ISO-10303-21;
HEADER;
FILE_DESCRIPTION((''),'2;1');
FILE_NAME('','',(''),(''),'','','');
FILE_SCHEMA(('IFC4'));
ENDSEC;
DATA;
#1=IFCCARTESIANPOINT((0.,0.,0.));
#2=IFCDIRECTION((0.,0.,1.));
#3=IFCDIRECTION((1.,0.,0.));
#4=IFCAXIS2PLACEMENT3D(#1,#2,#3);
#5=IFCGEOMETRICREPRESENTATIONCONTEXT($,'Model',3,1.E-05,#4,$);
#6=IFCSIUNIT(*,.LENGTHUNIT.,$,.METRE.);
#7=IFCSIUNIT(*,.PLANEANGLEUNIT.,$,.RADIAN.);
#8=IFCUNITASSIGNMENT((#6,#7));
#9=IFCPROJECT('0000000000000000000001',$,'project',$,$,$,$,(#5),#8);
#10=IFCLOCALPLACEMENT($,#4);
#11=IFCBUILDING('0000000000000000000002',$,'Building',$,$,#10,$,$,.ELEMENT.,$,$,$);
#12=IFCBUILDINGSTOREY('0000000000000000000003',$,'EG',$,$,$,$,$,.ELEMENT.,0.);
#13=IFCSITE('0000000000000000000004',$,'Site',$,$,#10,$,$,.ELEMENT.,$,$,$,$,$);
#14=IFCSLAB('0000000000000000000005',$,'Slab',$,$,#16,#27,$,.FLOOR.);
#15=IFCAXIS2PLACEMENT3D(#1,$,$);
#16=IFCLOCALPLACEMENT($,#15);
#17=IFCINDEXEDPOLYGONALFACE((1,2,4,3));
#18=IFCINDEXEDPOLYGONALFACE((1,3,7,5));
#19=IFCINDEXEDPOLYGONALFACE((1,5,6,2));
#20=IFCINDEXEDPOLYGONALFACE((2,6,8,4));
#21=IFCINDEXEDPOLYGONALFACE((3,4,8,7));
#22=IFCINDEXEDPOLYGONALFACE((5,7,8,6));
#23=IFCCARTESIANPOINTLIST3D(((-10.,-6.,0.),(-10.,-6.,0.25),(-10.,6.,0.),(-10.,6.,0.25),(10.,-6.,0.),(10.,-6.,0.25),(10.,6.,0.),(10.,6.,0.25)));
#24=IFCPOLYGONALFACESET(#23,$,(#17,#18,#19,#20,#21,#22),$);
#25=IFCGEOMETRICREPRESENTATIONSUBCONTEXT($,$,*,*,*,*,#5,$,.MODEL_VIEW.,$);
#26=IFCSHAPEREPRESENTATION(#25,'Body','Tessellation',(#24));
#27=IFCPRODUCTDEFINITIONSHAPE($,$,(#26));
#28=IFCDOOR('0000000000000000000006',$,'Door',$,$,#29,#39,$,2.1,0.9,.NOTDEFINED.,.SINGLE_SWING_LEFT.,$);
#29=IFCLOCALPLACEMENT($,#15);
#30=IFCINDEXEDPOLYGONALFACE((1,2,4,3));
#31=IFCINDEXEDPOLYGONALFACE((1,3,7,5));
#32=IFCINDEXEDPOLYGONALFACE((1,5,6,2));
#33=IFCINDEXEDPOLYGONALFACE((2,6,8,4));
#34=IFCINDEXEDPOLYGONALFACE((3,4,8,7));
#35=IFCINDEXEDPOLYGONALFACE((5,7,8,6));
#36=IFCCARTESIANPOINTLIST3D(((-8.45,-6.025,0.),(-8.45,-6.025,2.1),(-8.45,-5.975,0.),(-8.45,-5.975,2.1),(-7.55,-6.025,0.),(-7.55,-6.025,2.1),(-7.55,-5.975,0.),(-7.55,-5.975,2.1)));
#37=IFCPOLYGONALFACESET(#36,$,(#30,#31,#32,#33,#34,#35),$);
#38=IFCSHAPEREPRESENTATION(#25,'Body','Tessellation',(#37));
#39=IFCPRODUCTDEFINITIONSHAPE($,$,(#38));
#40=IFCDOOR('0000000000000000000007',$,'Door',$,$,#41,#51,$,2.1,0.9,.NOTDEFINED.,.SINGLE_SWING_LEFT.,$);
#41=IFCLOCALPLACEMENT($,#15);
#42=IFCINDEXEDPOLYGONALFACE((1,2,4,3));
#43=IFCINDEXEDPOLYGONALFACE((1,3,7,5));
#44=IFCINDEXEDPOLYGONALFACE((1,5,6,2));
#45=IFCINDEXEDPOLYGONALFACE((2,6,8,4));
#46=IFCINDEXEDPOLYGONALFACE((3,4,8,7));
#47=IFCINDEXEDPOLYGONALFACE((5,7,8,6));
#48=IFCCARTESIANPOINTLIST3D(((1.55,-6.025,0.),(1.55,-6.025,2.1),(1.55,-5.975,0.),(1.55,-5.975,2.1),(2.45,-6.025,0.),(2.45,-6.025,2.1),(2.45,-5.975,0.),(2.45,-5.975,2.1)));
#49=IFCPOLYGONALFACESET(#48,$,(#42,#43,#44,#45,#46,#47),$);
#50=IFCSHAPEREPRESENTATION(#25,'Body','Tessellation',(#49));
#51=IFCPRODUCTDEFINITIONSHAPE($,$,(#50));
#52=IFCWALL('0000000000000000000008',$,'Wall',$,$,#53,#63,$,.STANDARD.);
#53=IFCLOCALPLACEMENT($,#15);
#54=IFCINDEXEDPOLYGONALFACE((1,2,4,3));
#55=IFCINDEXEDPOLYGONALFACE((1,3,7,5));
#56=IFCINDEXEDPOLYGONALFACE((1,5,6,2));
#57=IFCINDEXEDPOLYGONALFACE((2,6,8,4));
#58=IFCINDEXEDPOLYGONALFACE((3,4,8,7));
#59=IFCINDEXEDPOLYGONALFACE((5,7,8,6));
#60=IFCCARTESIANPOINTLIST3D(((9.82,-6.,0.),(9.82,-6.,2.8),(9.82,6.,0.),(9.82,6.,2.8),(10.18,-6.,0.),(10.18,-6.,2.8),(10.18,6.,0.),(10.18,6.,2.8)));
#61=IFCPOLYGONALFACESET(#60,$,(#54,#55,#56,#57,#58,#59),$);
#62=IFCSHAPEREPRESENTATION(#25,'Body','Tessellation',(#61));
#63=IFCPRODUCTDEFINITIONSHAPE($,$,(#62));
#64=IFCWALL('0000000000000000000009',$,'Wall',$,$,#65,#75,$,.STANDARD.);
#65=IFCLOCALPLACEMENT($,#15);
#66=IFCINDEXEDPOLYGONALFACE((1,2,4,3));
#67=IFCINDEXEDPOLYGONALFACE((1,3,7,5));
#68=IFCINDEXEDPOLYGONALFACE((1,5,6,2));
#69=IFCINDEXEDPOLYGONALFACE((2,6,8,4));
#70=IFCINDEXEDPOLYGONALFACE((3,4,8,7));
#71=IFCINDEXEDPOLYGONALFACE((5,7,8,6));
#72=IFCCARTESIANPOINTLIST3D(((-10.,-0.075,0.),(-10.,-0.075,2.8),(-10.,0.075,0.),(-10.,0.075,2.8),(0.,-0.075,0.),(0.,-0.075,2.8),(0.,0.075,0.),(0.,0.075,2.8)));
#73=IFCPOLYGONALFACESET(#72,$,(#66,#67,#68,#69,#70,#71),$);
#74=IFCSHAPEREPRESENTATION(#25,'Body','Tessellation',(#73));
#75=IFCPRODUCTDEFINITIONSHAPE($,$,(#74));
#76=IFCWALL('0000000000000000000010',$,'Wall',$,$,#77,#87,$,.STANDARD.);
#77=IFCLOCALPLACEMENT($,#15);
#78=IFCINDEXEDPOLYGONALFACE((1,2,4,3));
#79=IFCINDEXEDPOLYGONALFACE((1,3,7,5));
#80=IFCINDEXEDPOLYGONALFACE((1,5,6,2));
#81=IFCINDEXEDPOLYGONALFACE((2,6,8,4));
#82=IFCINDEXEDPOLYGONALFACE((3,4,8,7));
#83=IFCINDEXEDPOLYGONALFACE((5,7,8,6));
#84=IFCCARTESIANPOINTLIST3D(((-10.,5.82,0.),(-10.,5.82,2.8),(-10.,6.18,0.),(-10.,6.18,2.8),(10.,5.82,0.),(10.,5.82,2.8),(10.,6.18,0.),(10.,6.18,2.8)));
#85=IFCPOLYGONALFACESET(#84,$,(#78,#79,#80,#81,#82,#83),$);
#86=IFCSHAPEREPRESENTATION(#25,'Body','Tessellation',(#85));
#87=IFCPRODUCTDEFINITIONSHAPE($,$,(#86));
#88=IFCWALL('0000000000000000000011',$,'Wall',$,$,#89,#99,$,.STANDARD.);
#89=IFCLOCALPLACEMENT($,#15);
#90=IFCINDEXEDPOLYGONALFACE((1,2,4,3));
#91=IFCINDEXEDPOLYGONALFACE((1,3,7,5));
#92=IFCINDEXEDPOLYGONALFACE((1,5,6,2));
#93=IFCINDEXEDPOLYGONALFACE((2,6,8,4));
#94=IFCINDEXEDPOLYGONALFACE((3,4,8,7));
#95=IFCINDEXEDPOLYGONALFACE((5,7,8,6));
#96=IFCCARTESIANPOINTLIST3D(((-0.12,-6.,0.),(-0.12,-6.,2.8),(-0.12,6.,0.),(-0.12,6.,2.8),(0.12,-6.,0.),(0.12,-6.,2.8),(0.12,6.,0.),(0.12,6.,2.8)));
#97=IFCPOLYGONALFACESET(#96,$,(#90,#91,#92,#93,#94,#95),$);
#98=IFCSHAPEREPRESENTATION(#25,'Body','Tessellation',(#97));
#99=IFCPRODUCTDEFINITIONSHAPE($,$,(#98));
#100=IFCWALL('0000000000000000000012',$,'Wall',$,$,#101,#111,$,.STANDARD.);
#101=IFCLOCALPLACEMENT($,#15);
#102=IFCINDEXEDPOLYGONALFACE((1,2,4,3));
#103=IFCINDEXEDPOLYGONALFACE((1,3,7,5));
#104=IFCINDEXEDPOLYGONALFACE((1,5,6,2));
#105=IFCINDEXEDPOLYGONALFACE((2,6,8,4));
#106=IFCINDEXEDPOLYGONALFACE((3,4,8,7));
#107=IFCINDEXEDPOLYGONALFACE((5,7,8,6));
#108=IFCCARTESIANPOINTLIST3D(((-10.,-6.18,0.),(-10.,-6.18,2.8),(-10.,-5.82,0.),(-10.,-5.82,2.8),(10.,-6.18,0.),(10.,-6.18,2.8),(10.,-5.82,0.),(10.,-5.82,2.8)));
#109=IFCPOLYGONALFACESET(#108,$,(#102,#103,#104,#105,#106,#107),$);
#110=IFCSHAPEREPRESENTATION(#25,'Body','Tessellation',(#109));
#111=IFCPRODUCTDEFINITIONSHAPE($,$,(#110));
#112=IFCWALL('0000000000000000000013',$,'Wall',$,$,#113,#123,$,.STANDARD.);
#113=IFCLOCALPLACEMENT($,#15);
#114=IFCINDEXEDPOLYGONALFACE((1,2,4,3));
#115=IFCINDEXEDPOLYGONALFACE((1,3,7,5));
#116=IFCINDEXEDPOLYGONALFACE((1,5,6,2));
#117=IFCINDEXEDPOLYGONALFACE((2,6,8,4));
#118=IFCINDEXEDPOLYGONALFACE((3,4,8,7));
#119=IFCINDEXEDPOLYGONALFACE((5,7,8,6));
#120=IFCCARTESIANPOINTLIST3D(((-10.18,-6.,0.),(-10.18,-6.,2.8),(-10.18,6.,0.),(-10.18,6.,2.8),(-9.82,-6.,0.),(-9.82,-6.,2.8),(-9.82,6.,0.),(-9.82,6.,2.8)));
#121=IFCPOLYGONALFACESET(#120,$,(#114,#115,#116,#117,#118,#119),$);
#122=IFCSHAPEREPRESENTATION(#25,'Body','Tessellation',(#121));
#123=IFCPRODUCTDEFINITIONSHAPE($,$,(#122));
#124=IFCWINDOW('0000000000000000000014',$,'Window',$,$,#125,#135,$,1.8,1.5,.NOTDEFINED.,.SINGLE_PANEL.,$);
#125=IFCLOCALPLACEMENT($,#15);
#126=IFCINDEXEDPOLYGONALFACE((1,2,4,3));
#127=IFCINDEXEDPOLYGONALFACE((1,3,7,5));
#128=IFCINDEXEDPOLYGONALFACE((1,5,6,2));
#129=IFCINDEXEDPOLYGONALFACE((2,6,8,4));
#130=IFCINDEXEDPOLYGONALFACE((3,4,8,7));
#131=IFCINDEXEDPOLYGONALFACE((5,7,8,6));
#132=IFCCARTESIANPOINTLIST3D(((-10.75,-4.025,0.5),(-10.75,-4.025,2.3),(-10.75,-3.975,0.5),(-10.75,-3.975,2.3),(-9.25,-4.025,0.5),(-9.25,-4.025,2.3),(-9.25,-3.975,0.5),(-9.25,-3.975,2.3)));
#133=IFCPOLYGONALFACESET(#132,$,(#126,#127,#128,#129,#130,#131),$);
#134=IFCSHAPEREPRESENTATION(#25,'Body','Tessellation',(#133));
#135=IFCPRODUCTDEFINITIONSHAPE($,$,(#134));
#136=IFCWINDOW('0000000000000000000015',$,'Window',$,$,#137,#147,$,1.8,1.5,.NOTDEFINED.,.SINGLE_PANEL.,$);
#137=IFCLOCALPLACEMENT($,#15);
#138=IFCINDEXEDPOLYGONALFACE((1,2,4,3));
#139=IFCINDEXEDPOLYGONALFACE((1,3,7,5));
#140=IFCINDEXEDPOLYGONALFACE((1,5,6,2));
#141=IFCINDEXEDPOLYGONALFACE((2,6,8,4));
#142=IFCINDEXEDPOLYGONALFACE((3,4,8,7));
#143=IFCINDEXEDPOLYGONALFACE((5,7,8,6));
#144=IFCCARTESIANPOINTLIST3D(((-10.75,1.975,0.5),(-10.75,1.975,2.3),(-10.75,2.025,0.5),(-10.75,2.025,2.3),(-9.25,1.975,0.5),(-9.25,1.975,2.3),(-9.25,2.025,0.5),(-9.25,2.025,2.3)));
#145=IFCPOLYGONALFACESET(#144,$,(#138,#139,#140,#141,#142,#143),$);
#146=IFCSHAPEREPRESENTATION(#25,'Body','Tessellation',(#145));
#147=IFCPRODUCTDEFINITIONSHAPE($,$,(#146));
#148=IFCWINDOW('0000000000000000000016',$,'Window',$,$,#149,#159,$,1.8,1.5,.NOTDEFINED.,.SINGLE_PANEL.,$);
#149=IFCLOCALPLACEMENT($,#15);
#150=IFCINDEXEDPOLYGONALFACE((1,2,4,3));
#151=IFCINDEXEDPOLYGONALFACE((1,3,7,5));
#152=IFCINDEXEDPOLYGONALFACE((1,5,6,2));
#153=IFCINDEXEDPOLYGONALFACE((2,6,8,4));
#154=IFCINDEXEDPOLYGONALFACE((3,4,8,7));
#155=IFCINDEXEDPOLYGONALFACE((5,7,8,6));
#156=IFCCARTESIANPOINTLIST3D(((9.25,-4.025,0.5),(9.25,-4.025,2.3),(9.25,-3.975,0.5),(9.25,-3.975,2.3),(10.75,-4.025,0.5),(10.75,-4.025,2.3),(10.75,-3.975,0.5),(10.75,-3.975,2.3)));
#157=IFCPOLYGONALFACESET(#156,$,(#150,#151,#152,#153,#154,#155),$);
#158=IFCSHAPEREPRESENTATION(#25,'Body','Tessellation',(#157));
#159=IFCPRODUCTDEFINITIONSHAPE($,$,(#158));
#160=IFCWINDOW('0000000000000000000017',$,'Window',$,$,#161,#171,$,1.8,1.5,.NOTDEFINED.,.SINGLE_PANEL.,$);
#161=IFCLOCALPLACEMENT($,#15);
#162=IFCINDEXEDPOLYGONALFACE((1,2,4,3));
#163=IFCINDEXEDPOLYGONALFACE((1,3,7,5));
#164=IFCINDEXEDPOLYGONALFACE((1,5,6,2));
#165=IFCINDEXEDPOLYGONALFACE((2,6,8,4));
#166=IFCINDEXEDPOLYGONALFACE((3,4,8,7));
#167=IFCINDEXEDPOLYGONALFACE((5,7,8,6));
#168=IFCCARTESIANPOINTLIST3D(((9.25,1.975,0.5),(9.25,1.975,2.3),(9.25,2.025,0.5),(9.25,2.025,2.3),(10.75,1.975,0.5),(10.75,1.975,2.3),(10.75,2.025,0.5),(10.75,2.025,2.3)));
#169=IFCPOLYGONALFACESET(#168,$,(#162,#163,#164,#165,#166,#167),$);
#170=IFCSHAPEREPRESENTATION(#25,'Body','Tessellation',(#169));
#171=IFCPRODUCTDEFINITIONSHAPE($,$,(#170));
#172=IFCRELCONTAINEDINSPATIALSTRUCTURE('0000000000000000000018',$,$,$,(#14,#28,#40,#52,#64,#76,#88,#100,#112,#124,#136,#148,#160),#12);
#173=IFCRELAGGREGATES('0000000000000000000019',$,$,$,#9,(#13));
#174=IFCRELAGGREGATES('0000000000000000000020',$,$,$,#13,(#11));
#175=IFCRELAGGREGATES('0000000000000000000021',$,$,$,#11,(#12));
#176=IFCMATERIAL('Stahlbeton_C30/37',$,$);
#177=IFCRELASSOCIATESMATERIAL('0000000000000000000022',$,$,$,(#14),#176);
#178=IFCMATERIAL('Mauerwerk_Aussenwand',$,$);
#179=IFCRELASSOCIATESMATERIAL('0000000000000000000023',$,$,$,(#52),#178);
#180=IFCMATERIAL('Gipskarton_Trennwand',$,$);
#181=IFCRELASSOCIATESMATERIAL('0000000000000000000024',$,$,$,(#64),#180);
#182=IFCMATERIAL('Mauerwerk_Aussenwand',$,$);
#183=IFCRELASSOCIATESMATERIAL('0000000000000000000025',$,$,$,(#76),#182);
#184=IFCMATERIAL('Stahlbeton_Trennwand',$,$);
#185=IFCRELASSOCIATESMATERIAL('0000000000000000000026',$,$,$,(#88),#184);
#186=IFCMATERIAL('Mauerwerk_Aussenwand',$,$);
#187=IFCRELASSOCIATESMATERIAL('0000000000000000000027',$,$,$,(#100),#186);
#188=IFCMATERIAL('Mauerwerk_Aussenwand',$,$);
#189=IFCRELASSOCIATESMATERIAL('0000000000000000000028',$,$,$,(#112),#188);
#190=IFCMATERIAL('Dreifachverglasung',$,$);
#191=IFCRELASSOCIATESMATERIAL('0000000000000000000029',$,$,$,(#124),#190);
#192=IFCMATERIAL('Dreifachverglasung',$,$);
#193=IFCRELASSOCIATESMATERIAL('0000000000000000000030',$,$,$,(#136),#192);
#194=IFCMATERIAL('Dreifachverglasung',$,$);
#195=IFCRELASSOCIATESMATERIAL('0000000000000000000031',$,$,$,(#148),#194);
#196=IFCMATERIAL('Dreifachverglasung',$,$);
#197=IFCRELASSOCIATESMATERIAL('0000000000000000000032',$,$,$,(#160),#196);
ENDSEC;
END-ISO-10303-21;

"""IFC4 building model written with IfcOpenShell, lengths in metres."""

from ifc_helpers import new_model, si_unit, frame, frame_2d, origin, origin_with_axes, origin_2d, place, context, subcontext, project, spatial, rectangle, extrude, material, element, save


model = new_model("IFC4")

# Units and contexts
model_context = context("Model", 3, precision=1e-05, world=origin_with_axes())
sub_context = subcontext(model_context, None, None, "MODEL_VIEW")
ifc_project = project(units=[si_unit("LENGTHUNIT", "METRE"), si_unit("PLANEANGLEUNIT", "RADIAN")], contexts=[model_context])

# Site, building, storey
placement_1 = place(None, origin_with_axes())
site = spatial("IfcSite", under=ifc_project, at=placement_1, Name="Site", CompositionType="ELEMENT")
building = spatial("IfcBuilding", under=site, at=placement_1, Name="Building", CompositionType="ELEMENT")
storey = spatial("IfcBuildingStorey", under=building, Name="EG", CompositionType="ELEMENT", Elevation=0.0)

# Slab
ifc_material_1 = material(Name="Stahlbeton_C30/37")
placement_2 = place(None, origin_with_axes())
placement_3 = place(placement_2, origin())
slab_placement = place(placement_3, frame((-10.0, -6.0, 0.0)))
element("IfcSlab", 1, at=slab_placement, inside=storey, material=ifc_material_1, Name="Slab", PredefinedType="FLOOR", context=sub_context, shape_type="SweptSolid", body=[
    extrude(rectangle(XDim=20.0, YDim=12.0, at=frame_2d((10.0, 6.0))), origin(), (0.0, 0.0, 1.0), 0.25),
])

# Doors
door_1_placement = place(placement_1, frame((-8.0, -6.0, 0.0)))
element("IfcDoor", 2, at=door_1_placement, inside=storey, Name="Door", OperationType="SINGLE_SWING_LEFT", OverallHeight=2.1, OverallWidth=0.9, PredefinedType="NOTDEFINED", context=sub_context, shape_type="SweptSolid", body=[
    extrude(rectangle(XDim=0.9, YDim=0.05, at=origin_2d()), origin(), (0.0, 0.0, 1.0), 2.1),
])
placement_4 = place(None, origin_with_axes())
door_2_placement = place(placement_4, frame((2.0, -6.0, 0.0)))
element("IfcDoor", 3, at=door_2_placement, inside=storey, Name="Door", OperationType="SINGLE_SWING_LEFT", OverallHeight=2.1, OverallWidth=0.9, PredefinedType="NOTDEFINED", context=sub_context, shape_type="SweptSolid", body=[
    extrude(rectangle(XDim=0.9, YDim=0.05, at=origin_2d()), origin(), (0.0, 0.0, 1.0), 2.1),
])

# Walls
ifc_material_2 = material(Name="Mauerwerk_Aussenwand")
placement_5 = place(None, origin_with_axes())
placement_6 = place(placement_5, origin())
wall_1_placement = place(placement_6, frame((10.0, -6.0, 0.0), x_axis=(0.0, 1.0, 0.0)))
element("IfcWall", 4, at=wall_1_placement, inside=storey, material=ifc_material_2, Name="Wall", PredefinedType="STANDARD", context=sub_context, shape_type="SweptSolid", body=[
    extrude(rectangle(XDim=12.0, YDim=0.36, at=frame_2d((6.0, 0.0))), origin(), (0.0, 0.0, 1.0), 2.8),
])
ifc_material_3 = material(Name="Gipskarton_Trennwand")
placement_7 = place(None, origin_with_axes())
placement_8 = place(placement_7, origin())
wall_2_placement = place(placement_8, frame((-10.0, 0.0, 0.0), x_axis=(1.0, 0.0, 0.0)))
element("IfcWall", 5, at=wall_2_placement, inside=storey, material=ifc_material_3, Name="Wall", PredefinedType="STANDARD", context=sub_context, shape_type="SweptSolid", body=[
    extrude(rectangle(XDim=10.0, YDim=0.15, at=frame_2d((5.0, 0.0))), origin(), (0.0, 0.0, 1.0), 2.8),
])
ifc_material_4 = material(Name="Mauerwerk_Aussenwand")
placement_9 = place(None, origin_with_axes())
placement_10 = place(placement_9, origin())
wall_3_placement = place(placement_10, frame((-10.0, 6.0, 0.0), x_axis=(1.0, 0.0, 0.0)))
element("IfcWall", 6, at=wall_3_placement, inside=storey, material=ifc_material_4, Name="Wall", PredefinedType="STANDARD", context=sub_context, shape_type="SweptSolid", body=[
    extrude(rectangle(XDim=20.0, YDim=0.36, at=frame_2d((10.0, 0.0))), origin(), (0.0, 0.0, 1.0), 2.8),
])
ifc_material_5 = material(Name="Stahlbeton_Trennwand")
placement_11 = place(None, origin_with_axes())
placement_12 = place(placement_11, origin())
wall_4_placement = place(placement_12, frame((0.0, -6.0, 0.0), x_axis=(0.0, 1.0, 0.0)))
element("IfcWall", 7, at=wall_4_placement, inside=storey, material=ifc_material_5, Name="Wall", PredefinedType="STANDARD", context=sub_context, shape_type="SweptSolid", body=[
    extrude(rectangle(XDim=12.0, YDim=0.24, at=frame_2d((6.0, 0.0))), origin(), (0.0, 0.0, 1.0), 2.8),
])
ifc_material_6 = material(Name="Mauerwerk_Aussenwand")
placement_13 = place(None, origin_with_axes())
placement_14 = place(placement_13, origin())
wall_5_placement = place(placement_14, frame((-10.0, -6.0, 0.0), x_axis=(1.0, 0.0, 0.0)))
element("IfcWall", 8, at=wall_5_placement, inside=storey, material=ifc_material_6, Name="Wall", PredefinedType="STANDARD", context=sub_context, shape_type="SweptSolid", body=[
    extrude(rectangle(XDim=20.0, YDim=0.36, at=frame_2d((10.0, 0.0))), origin(), (0.0, 0.0, 1.0), 2.8),
])
ifc_material_7 = material(Name="Mauerwerk_Aussenwand")
placement_15 = place(None, origin_with_axes())
placement_16 = place(placement_15, origin())
wall_6_placement = place(placement_16, frame((-10.0, -6.0, 0.0), x_axis=(0.0, 1.0, 0.0)))
element("IfcWall", 9, at=wall_6_placement, inside=storey, material=ifc_material_7, Name="Wall", PredefinedType="STANDARD", context=sub_context, shape_type="SweptSolid", body=[
    extrude(rectangle(XDim=12.0, YDim=0.36, at=frame_2d((6.0, 0.0))), origin(), (0.0, 0.0, 1.0), 2.8),
])

# Windows
ifc_material_8 = material(Name="Dreifachverglasung")
placement_17 = place(None, origin_with_axes())
window_1_placement = place(placement_17, frame((-10.0, -4.0, 0.5)))
element("IfcWindow", 10, at=window_1_placement, inside=storey, material=ifc_material_8, Name="Window", OverallHeight=1.8, OverallWidth=1.5, PartitioningType="SINGLE_PANEL", PredefinedType="NOTDEFINED", context=sub_context, shape_type="SweptSolid", body=[
    extrude(rectangle(XDim=1.5, YDim=0.05, at=origin_2d()), origin(), (0.0, 0.0, 1.0), 1.8),
])
ifc_material_9 = material(Name="Dreifachverglasung")
placement_18 = place(None, origin_with_axes())
window_2_placement = place(placement_18, frame((-10.0, 2.0, 0.5)))
element("IfcWindow", 11, at=window_2_placement, inside=storey, material=ifc_material_9, Name="Window", OverallHeight=1.8, OverallWidth=1.5, PartitioningType="SINGLE_PANEL", PredefinedType="NOTDEFINED", context=sub_context, shape_type="SweptSolid", body=[
    extrude(rectangle(XDim=1.5, YDim=0.05, at=origin_2d()), origin(), (0.0, 0.0, 1.0), 1.8),
])
ifc_material_10 = material(Name="Dreifachverglasung")
placement_19 = place(None, origin_with_axes())
window_3_placement = place(placement_19, frame((10.0, -4.0, 0.5)))
element("IfcWindow", 12, at=window_3_placement, inside=storey, material=ifc_material_10, Name="Window", OverallHeight=1.8, OverallWidth=1.5, PartitioningType="SINGLE_PANEL", PredefinedType="NOTDEFINED", context=sub_context, shape_type="SweptSolid", body=[
    extrude(rectangle(XDim=1.5, YDim=0.05, at=origin_2d()), origin(), (0.0, 0.0, 1.0), 1.8),
])
ifc_material_11 = material(Name="Dreifachverglasung")
placement_20 = place(None, origin_with_axes())
window_4_placement = place(placement_20, frame((10.0, 2.0, 0.5)))
element("IfcWindow", 13, at=window_4_placement, inside=storey, material=ifc_material_11, Name="Window", OverallHeight=1.8, OverallWidth=1.5, PartitioningType="SINGLE_PANEL", PredefinedType="NOTDEFINED", context=sub_context, shape_type="SweptSolid", body=[
    extrude(rectangle(XDim=1.5, YDim=0.05, at=origin_2d()), origin(), (0.0, 0.0, 1.0), 1.8),
])

save(model, "model.ifc")
